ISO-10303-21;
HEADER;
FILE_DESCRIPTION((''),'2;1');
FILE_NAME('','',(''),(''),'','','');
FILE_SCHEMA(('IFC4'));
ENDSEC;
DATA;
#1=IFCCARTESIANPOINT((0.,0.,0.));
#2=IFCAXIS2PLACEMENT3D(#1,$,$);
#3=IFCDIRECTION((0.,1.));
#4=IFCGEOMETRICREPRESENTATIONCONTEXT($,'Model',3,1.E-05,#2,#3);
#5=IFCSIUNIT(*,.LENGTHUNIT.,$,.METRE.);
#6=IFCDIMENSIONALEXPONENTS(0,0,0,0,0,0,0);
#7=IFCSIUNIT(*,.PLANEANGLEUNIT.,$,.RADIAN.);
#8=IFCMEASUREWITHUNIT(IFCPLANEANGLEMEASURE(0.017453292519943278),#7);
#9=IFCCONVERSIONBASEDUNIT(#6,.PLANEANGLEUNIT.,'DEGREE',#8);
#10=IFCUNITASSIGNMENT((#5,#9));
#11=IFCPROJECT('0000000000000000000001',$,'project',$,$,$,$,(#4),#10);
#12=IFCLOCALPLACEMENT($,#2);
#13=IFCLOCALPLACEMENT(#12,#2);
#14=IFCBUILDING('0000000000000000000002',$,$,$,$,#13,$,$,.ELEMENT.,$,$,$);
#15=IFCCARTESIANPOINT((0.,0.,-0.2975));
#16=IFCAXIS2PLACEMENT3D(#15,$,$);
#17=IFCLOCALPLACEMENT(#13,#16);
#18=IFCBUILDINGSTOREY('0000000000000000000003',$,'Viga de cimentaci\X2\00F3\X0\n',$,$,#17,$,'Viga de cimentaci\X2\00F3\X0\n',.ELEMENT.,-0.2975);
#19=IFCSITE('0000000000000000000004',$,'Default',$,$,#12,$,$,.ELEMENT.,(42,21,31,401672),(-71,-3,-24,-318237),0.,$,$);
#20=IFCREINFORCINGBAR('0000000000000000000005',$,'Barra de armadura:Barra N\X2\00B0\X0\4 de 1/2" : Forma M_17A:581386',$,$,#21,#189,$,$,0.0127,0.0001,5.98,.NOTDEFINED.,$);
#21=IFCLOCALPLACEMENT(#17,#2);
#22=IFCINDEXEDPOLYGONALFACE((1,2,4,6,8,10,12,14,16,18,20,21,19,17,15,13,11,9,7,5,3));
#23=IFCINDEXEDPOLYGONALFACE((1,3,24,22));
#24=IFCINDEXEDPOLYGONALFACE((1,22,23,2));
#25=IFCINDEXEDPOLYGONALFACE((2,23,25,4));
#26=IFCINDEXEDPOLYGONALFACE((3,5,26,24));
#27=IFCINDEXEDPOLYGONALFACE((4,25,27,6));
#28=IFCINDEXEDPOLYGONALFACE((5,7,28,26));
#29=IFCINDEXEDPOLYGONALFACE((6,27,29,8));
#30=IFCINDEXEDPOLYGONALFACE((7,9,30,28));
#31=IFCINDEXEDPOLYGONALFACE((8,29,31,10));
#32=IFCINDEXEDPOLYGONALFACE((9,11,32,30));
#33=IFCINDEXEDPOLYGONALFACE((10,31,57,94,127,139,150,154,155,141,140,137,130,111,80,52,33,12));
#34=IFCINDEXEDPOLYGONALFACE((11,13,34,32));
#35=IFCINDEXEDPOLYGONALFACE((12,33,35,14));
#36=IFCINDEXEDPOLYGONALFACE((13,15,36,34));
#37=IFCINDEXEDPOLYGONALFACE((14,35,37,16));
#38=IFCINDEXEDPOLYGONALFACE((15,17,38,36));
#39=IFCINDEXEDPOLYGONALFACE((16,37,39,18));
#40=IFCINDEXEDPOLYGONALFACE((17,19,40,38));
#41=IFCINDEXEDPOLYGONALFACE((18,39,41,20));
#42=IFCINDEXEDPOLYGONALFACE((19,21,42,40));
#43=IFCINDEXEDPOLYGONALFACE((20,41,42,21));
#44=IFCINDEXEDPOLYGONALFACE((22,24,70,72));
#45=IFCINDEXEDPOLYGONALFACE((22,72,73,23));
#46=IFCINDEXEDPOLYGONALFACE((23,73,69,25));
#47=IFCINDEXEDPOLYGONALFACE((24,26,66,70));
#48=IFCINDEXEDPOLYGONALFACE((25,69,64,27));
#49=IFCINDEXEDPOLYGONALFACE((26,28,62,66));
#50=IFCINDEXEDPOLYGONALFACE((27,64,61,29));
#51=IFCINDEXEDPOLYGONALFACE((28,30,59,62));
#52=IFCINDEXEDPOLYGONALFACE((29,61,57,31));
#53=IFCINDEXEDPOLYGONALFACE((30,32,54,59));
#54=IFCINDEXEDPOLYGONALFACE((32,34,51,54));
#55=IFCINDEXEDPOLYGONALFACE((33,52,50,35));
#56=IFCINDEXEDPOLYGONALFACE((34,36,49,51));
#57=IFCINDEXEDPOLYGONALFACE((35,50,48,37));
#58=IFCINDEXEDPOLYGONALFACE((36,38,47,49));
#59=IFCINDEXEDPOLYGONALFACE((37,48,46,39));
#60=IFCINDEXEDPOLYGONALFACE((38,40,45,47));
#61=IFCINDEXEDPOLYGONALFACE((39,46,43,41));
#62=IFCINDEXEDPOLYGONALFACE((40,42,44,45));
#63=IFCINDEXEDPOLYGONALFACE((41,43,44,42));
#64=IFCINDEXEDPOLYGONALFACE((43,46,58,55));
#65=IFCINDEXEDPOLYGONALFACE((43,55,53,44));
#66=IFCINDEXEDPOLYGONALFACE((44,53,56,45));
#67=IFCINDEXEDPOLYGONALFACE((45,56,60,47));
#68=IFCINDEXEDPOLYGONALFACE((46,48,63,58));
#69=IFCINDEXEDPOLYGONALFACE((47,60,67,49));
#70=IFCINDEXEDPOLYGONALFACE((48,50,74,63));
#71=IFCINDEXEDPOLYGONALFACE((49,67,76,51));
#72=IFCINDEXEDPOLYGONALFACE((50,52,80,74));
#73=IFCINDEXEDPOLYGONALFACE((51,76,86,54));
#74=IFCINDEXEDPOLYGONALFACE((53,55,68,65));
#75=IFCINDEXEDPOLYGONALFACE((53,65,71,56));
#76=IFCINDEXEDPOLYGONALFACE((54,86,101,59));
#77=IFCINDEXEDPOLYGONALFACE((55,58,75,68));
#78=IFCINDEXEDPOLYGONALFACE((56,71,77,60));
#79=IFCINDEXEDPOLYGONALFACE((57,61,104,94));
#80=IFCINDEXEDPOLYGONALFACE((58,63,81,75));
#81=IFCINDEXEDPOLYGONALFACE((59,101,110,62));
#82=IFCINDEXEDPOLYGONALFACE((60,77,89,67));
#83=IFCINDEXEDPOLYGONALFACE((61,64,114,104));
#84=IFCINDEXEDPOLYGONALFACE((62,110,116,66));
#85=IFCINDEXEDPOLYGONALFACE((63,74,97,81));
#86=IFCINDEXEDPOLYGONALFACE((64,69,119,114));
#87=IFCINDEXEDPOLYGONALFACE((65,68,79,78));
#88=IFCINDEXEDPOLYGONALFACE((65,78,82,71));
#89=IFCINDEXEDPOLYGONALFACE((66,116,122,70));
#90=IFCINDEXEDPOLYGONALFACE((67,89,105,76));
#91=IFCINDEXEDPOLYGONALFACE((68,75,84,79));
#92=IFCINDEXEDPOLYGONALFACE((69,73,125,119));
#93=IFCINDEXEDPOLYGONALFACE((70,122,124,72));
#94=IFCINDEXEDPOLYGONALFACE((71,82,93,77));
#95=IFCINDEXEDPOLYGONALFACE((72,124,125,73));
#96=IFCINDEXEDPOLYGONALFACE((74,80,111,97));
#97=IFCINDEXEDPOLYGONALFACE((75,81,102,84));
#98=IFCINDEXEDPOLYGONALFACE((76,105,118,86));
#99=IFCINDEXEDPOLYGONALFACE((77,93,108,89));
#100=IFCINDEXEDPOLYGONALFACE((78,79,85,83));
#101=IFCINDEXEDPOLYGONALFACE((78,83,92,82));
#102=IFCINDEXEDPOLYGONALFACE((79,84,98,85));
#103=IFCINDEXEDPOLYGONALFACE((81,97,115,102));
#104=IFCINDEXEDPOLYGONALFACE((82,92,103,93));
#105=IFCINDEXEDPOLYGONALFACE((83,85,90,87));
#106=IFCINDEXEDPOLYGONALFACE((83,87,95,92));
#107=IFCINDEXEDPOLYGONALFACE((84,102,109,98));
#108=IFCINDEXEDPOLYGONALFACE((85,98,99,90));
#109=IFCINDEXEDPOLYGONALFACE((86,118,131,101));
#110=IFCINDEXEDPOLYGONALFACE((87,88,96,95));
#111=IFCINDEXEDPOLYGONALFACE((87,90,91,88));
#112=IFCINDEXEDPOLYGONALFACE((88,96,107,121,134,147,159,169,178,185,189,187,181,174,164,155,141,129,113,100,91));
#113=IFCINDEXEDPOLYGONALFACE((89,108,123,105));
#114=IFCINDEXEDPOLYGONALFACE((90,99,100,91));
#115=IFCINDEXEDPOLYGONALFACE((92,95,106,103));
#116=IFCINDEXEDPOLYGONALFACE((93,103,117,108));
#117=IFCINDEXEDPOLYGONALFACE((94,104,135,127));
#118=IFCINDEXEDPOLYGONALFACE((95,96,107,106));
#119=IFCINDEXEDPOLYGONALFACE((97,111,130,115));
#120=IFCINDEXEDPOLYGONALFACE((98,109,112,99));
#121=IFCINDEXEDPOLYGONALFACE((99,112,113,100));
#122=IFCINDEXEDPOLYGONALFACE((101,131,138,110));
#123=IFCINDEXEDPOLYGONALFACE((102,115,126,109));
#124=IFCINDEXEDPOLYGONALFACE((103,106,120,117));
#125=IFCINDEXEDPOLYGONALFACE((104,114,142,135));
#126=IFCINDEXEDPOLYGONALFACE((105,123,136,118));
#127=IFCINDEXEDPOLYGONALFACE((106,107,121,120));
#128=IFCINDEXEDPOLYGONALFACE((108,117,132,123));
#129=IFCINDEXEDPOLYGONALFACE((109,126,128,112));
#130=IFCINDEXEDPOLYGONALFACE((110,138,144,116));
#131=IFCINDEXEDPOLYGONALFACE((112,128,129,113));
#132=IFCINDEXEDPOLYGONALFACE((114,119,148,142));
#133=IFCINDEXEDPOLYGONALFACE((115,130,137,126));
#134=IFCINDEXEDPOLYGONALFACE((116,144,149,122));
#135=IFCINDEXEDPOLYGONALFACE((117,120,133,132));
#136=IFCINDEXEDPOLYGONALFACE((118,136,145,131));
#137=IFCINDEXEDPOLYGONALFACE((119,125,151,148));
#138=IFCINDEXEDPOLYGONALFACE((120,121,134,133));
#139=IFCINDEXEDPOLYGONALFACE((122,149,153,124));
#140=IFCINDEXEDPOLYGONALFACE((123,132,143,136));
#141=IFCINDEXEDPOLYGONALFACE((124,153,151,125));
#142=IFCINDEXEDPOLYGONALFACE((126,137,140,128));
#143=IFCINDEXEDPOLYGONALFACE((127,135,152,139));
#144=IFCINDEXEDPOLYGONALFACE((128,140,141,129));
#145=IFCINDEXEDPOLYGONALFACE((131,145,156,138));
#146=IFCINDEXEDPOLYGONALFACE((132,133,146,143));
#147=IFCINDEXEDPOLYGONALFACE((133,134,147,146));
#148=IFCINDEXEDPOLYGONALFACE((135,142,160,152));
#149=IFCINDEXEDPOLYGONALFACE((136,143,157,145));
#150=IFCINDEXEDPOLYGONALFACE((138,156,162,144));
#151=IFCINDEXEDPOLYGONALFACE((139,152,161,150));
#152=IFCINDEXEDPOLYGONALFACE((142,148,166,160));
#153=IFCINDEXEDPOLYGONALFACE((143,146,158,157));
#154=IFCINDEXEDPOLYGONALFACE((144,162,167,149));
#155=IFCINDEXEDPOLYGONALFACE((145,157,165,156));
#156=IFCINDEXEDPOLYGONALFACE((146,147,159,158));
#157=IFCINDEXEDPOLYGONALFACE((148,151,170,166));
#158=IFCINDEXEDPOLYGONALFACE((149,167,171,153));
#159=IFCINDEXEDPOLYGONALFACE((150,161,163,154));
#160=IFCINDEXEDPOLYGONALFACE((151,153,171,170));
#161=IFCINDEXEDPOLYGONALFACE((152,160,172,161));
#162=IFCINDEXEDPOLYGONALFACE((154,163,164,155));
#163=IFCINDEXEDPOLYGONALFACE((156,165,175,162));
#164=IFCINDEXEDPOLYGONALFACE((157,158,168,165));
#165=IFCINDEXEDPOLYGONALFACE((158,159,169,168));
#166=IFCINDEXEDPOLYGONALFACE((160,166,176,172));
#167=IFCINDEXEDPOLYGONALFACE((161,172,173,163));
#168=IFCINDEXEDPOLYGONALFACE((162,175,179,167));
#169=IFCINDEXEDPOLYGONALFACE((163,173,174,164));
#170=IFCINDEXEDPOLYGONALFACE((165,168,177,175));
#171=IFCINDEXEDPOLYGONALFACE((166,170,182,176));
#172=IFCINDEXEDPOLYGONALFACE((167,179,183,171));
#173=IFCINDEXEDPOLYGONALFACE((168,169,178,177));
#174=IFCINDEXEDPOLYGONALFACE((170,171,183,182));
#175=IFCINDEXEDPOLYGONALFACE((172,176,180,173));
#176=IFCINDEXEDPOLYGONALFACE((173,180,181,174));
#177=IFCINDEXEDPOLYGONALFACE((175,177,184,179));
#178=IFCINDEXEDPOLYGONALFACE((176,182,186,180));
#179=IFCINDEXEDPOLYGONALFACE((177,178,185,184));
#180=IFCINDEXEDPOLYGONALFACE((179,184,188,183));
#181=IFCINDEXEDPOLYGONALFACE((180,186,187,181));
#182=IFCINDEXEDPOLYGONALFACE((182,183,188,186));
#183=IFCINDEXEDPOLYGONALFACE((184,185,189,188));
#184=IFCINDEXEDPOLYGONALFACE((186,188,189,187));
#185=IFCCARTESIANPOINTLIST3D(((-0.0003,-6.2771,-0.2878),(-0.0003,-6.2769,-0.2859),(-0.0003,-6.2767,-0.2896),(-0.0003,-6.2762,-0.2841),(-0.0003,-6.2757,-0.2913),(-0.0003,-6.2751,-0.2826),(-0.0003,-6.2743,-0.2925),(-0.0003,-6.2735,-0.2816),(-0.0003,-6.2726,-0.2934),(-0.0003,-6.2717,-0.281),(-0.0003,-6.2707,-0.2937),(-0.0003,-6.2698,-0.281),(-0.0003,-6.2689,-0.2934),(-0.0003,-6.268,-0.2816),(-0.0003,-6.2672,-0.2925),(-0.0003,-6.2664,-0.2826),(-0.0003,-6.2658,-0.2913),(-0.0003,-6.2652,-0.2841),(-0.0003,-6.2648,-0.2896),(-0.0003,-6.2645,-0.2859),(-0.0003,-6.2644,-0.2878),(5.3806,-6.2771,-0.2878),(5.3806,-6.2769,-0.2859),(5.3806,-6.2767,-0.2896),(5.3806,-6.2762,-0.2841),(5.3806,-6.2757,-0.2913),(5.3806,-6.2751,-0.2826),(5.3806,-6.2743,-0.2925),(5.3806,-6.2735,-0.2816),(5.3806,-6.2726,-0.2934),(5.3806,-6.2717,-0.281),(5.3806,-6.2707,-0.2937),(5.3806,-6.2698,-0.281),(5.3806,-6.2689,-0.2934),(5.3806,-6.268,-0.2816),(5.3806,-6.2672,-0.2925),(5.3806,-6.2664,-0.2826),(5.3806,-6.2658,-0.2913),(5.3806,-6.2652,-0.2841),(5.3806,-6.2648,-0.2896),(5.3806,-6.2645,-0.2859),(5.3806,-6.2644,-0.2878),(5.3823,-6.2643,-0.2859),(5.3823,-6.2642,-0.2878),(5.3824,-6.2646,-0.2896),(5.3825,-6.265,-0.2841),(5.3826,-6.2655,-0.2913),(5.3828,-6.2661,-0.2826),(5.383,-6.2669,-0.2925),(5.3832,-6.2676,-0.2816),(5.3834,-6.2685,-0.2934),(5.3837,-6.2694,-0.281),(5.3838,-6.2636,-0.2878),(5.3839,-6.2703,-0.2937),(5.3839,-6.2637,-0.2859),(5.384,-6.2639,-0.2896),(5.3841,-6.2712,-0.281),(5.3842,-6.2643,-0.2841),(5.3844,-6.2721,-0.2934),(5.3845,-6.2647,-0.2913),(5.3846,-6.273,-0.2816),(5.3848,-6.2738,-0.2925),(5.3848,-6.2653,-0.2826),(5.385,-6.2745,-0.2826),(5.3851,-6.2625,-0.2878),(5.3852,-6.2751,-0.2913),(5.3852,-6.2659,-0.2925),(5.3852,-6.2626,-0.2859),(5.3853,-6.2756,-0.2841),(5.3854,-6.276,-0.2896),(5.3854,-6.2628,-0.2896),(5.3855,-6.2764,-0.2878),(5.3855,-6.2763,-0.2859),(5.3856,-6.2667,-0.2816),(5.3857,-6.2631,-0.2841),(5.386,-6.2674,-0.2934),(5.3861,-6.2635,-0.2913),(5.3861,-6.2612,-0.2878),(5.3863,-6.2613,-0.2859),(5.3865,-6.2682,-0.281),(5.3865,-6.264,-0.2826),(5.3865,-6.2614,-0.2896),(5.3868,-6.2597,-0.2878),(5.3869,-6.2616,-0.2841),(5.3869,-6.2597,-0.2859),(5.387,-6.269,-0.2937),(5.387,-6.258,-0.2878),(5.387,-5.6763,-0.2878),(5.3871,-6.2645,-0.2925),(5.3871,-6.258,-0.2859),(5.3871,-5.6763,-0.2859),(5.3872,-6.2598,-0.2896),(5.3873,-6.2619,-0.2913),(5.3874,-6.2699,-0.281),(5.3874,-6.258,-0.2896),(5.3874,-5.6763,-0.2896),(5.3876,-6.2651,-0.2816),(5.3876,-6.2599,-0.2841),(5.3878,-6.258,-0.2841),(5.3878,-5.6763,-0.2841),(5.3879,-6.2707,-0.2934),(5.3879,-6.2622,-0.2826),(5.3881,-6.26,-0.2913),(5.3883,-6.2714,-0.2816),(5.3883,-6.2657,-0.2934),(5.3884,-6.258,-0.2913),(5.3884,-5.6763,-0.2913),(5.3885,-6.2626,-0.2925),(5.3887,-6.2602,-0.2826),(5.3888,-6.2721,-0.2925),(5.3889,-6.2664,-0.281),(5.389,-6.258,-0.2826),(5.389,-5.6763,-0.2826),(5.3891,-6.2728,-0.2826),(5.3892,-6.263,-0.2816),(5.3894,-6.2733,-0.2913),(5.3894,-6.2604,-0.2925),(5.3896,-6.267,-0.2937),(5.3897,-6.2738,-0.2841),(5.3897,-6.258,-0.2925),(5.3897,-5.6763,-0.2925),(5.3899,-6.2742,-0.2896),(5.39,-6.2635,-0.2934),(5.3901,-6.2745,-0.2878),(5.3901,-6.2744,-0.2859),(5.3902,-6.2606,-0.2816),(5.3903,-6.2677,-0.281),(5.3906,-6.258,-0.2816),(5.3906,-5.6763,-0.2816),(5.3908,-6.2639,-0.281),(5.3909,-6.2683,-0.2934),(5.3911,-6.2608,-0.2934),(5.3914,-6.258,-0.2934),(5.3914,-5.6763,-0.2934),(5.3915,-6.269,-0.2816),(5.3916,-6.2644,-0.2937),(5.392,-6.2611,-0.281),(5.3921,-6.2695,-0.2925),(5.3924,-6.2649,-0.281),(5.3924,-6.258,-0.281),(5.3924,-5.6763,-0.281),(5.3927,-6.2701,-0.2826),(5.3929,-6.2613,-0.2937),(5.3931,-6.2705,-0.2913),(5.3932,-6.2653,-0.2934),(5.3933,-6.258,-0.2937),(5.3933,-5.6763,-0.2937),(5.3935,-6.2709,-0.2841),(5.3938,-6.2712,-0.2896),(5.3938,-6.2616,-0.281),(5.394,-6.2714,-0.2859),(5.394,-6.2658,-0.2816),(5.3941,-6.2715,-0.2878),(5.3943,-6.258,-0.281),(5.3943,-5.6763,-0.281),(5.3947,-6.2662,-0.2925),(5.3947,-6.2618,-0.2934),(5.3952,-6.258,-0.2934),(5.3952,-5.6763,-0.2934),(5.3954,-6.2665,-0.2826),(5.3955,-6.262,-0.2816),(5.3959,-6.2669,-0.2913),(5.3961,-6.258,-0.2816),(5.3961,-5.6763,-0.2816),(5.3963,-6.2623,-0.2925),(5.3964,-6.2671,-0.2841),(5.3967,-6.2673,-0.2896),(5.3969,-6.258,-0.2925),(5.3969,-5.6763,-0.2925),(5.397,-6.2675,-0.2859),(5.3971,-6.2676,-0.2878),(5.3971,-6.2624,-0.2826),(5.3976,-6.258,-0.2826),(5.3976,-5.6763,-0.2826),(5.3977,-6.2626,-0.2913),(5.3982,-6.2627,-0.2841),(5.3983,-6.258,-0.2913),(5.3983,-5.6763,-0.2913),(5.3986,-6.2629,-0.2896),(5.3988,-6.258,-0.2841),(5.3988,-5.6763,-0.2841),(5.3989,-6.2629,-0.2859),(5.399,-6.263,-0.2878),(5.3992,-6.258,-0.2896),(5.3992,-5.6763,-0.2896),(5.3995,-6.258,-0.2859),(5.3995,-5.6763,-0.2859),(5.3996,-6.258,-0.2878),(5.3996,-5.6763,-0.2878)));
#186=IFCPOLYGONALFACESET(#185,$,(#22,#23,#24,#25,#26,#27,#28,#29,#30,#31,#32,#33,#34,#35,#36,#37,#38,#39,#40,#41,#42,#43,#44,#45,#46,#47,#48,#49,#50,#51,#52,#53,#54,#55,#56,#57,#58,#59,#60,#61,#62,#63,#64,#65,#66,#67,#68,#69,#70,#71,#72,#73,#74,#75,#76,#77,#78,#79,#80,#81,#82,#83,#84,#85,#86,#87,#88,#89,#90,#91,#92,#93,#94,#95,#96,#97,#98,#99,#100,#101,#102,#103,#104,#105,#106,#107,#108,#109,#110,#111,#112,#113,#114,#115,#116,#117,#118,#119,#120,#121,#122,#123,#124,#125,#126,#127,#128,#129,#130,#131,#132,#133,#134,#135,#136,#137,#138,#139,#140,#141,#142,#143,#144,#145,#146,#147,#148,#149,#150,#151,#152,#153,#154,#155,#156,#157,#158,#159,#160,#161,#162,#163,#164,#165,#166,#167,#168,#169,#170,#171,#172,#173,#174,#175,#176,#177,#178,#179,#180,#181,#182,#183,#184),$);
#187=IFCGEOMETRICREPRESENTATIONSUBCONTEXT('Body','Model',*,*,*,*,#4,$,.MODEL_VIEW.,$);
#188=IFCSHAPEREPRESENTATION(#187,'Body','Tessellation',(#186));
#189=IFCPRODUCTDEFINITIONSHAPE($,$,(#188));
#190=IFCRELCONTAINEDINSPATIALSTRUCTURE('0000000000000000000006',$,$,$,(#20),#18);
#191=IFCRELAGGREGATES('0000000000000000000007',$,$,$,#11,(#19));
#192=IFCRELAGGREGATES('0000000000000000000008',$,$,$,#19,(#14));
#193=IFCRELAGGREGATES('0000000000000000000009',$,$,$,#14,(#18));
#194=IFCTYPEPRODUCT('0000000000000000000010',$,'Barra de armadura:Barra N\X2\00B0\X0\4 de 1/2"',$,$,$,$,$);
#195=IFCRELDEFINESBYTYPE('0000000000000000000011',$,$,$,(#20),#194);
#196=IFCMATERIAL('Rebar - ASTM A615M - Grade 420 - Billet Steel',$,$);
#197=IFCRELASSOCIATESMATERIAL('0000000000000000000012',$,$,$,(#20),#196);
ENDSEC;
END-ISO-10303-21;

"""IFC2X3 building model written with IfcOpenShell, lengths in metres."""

from ifc_helpers import new_model, entity, si_unit, converted_unit, direction, frame, origin, place, context, subcontext, project, spatial, material, type_object, element, save


model = new_model("IFC2X3")

# Units and contexts
model_context = context("Model", 3, precision=1e-05, world=origin(), true_north=direction((0.0, 1.0)))
body_context = subcontext(model_context, "Body", "Model", "MODEL_VIEW")
ifc_project = project(units=[si_unit("LENGTHUNIT", "METRE"), converted_unit("PLANEANGLEUNIT", "DEGREE", entity("IfcPlaneAngleMeasure", 0.017453292519943278), si_unit("PLANEANGLEUNIT", "RADIAN"), dimensions=[0, 0, 0, 0, 0, 0, 0])], contexts=[model_context])

# Site, building, storey
site_placement = place(None, origin())
site = spatial("IfcSite", under=ifc_project, at=site_placement, Name="Default", CompositionType="ELEMENT", RefLatitude=(42, 21, 31, 401672), RefLongitude=(-71, -3, -24, -318237), RefElevation=0.0)
building_placement = place(site_placement, origin())
building = spatial("IfcBuilding", under=site, at=building_placement, CompositionType="ELEMENT")
storey_placement = place(building_placement, frame((0.0, 0.0, -0.2975)))
storey = spatial("IfcBuildingStorey", under=building, at=storey_placement, Name="Viga de cimentación", LongName="Viga de cimentación", CompositionType="ELEMENT", Elevation=-0.2975)

# Reinforcing bar
ifc_material = material(Name="Rebar - ASTM A615M - Grade 420 - Billet Steel")
type_product_1 = type_object("IfcTypeProduct", Name="Barra de armadura:Barra N°4 de 1/2\"")
reinforcing_bar_1_placement = place(storey_placement, origin())
element("IfcReinforcingBar", 1, at=reinforcing_bar_1_placement, inside=storey, type_object=type_product_1, material=ifc_material, Name="Barra de armadura:Barra N°4 de 1/2\" : Forma M_17A:581386", BarLength=5.98, BarRole="NOTDEFINED", CrossSectionArea=0.0001, NominalDiameter=0.0127, context=body_context, shape_type="AdvancedSweptSolid", body=[
    entity("IfcSweptDiskSolid", entity("IfcCompositeCurve", [entity("IfcCompositeCurveSegment", "CONTINUOUS", True, entity("IfcPolyline", [entity("IfcCartesianPoint", [5.3933, -5.6763, -0.2873]), entity("IfcCartesianPoint", [5.3933, -6.258, -0.2873])])), entity("IfcCompositeCurveSegment", "CONTINUOUS", True, entity("IfcTrimmedCurve", entity("IfcCircle", entity("IfcAxis2Placement3D", entity("IfcCartesianPoint", [5.3806, -6.258, -0.2873]), entity("IfcDirection", [0.0, 0.0, -1.0]), entity("IfcDirection", [0.0, -1.0, 0.0])), 0.0127), [entity("IfcParameterValue", 270.0)], [entity("IfcParameterValue", 360.0)], True, "PARAMETER")), entity("IfcCompositeCurveSegment", "CONTINUOUS", True, entity("IfcPolyline", [entity("IfcCartesianPoint", [5.3806, -6.2707, -0.2873]), entity("IfcCartesianPoint", [-0.0003, -6.2707, -0.2873])]))], False), 0.0063, None, 0.0, 92.0),
])

save(model, "model.ifc")
